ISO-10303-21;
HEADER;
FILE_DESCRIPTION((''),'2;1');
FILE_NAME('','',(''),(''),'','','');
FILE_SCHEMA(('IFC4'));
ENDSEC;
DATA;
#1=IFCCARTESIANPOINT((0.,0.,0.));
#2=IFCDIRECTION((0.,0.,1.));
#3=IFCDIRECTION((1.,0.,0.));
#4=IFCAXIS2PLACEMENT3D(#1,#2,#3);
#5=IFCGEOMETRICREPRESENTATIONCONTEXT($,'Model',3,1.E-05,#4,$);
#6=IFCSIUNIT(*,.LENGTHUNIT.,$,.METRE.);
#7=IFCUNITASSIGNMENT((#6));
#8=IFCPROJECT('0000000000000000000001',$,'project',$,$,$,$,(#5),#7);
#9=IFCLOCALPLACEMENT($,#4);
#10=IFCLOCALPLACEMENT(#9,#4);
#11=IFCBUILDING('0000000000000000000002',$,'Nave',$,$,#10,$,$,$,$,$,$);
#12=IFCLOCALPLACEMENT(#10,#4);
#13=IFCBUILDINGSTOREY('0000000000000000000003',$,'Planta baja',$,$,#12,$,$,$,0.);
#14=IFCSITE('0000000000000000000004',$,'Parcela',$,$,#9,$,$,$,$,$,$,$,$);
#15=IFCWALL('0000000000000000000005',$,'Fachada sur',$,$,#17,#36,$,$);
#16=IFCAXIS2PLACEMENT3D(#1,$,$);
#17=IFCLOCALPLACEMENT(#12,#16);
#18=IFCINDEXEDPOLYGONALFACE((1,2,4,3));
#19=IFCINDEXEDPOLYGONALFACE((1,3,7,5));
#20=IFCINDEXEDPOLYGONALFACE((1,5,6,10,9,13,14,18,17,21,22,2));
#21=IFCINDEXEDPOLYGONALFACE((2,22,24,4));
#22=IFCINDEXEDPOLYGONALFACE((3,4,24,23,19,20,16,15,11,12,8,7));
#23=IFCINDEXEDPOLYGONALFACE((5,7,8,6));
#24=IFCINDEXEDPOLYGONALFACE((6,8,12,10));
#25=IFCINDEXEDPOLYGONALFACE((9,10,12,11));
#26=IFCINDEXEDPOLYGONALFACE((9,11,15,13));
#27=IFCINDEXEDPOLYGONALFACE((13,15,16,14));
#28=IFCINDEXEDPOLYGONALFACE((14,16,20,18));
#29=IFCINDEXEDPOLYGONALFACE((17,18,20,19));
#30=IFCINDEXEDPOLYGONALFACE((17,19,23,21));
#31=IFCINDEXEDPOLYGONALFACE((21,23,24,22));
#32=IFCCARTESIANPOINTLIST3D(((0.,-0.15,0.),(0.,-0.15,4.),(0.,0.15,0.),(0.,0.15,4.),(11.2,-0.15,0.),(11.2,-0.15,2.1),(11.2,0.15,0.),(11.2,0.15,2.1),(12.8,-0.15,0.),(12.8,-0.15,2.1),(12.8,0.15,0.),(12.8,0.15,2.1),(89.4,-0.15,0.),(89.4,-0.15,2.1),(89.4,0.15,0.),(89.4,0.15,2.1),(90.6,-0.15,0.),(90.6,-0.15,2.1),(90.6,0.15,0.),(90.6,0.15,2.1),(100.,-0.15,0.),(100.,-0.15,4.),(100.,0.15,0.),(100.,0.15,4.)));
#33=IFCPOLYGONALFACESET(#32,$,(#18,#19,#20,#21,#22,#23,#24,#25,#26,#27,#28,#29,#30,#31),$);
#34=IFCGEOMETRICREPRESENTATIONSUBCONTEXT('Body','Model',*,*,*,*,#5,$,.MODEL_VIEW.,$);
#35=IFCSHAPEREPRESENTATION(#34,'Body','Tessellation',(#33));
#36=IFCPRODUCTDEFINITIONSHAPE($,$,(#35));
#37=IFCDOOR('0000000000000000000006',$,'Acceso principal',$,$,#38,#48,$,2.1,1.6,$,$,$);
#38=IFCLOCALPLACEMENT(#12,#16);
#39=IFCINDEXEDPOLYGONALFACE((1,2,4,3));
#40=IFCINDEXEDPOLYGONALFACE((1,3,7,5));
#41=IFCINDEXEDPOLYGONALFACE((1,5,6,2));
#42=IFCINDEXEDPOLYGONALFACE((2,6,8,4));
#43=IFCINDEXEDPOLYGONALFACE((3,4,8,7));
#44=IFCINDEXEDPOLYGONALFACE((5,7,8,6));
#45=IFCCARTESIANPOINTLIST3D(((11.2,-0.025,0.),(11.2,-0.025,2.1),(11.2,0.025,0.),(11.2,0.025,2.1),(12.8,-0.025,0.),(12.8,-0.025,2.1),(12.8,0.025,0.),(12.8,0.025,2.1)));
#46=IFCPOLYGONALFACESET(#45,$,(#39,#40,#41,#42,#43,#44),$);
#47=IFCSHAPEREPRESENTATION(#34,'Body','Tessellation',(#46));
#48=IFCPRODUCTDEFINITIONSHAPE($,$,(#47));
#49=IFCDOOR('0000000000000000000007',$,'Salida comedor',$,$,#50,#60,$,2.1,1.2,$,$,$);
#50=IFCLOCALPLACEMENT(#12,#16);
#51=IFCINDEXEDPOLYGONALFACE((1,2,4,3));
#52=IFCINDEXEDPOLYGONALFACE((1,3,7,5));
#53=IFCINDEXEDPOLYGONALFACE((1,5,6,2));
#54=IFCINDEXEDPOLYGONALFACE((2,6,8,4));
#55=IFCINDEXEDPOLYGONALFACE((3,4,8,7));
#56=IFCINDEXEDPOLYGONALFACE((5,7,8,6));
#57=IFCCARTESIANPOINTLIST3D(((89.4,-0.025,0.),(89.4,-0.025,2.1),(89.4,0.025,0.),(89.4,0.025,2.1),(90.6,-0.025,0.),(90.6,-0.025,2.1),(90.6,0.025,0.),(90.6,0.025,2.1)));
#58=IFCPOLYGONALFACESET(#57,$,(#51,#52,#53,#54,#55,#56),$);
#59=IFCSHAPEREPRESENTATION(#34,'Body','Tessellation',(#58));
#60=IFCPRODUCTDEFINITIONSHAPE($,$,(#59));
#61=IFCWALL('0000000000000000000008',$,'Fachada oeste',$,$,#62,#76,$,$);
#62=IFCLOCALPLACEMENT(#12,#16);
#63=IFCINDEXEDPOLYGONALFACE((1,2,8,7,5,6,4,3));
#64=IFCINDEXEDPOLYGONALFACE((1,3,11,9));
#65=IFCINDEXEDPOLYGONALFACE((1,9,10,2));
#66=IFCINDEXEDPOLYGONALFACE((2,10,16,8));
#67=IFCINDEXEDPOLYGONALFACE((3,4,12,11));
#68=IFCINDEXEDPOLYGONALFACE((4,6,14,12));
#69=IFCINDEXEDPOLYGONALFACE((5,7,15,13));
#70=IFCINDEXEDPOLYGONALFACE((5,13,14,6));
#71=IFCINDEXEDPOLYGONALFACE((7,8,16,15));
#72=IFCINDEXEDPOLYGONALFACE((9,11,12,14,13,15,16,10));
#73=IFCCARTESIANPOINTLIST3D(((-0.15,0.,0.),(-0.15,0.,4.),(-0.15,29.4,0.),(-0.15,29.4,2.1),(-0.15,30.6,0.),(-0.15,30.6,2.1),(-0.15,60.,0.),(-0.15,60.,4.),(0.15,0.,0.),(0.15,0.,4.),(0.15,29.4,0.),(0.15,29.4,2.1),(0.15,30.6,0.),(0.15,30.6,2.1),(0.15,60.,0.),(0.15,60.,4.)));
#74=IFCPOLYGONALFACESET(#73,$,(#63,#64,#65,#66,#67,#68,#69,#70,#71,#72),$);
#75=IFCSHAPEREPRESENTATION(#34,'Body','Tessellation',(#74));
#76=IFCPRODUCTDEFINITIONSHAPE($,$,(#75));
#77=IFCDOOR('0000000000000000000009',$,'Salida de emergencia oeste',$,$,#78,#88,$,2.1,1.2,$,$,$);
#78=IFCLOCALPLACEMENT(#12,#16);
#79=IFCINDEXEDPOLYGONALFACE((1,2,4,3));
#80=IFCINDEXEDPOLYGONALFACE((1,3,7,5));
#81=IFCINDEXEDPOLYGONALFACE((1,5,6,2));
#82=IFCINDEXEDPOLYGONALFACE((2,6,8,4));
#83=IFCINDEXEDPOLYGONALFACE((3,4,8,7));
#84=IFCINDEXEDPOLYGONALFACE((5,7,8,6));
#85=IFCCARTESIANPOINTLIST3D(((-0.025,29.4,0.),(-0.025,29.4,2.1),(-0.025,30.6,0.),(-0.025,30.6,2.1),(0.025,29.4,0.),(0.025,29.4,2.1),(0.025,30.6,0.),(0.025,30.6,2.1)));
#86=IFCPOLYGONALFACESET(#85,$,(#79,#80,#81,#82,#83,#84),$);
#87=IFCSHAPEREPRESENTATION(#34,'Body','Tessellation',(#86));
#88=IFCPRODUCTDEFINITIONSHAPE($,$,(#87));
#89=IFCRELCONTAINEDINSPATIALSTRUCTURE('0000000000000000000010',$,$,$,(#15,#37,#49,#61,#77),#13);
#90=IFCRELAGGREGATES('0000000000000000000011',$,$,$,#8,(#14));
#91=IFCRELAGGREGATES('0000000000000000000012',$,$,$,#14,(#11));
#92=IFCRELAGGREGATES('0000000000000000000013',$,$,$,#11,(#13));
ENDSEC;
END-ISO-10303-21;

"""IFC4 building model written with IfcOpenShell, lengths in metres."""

from ifc_helpers import new_model, si_unit, frame, origin_with_axes, place, context, subcontext, project, spatial, indexed_curve, outline, extrude, element, fill, save


model = new_model("IFC4")

# Units and contexts
model_context = context("Model", 3, precision=1e-05, world=origin_with_axes())
body_context = subcontext(model_context, "Body", "Model", "MODEL_VIEW")
ifc_project = project(units=[si_unit("LENGTHUNIT", "METRE")], contexts=[model_context])

# Site, building, storey
site_placement = place(None, origin_with_axes())
site = spatial("IfcSite", under=ifc_project, at=site_placement, Name="Parcela")
building_placement = place(site_placement, origin_with_axes())
building = spatial("IfcBuilding", under=site, at=building_placement, Name="Nave")
storey_placement = place(building_placement, origin_with_axes())
storey = spatial("IfcBuildingStorey", under=building, at=storey_placement, Name="Planta baja", Elevation=0.0)

# Wall, openings, doors
wall_1_placement = place(storey_placement, frame((0.0, -0.15, 0.0), z_axis=(0.0, 0.0, 1.0), x_axis=(1.0, 0.0, 0.0)))
wall_1 = element("IfcWall", 1, at=wall_1_placement, inside=storey, Name="Fachada sur", context=body_context, shape_type="SweptSolid", body=[
    extrude(outline(indexed_curve([(0.0, 0.0), (0.0, 0.3), (100.0, 0.3), (100.0, 0.0), (0.0, 0.0)], self_intersect=False)), origin_with_axes(), (0.0, 0.0, 1.0), 4.0),
])
opening_1_placement = place(wall_1_placement, frame((11.2, -0.05, 0.0), z_axis=(0.0, 0.0, 1.0), x_axis=(1.0, 0.0, 0.0)))
opening_1 = element("IfcOpeningElement", 2, at=opening_1_placement, cuts=wall_1, context=body_context, shape_type="SweptSolid", body=[
    extrude(outline(indexed_curve([(0.0, 0.0), (0.0, 0.4), (1.6, 0.4), (1.6, 0.0), (0.0, 0.0)], self_intersect=False)), origin_with_axes(), (0.0, 0.0, 1.0), 2.1),
])
opening_2_placement = place(wall_1_placement, frame((89.4, -0.05, 0.0), z_axis=(0.0, 0.0, 1.0), x_axis=(1.0, 0.0, 0.0)))
opening_2 = element("IfcOpeningElement", 3, at=opening_2_placement, cuts=wall_1, context=body_context, shape_type="SweptSolid", body=[
    extrude(outline(indexed_curve([(0.0, 0.0), (0.0, 0.4), (1.2, 0.4), (1.2, 0.0), (0.0, 0.0)], self_intersect=False)), origin_with_axes(), (0.0, 0.0, 1.0), 2.1),
])
door_1_placement = place(opening_1_placement, frame((0.0, 0.175, 0.0), z_axis=(0.0, 0.0, 1.0), x_axis=(1.0, 0.0, 0.0)))
door_1 = element("IfcDoor", 4, at=door_1_placement, inside=storey, Name="Acceso principal", OverallHeight=2.1, OverallWidth=1.6, context=body_context, shape_type="SweptSolid", body=[
    extrude(outline(indexed_curve([(0.0, 0.0), (0.0, 0.05), (1.6, 0.05), (1.6, 0.0), (0.0, 0.0)], self_intersect=False)), origin_with_axes(), (0.0, 0.0, 1.0), 2.1),
])
fill(opening_1, door_1)
door_2_placement = place(opening_2_placement, frame((0.0, 0.175, 0.0), z_axis=(0.0, 0.0, 1.0), x_axis=(1.0, 0.0, 0.0)))
door_2 = element("IfcDoor", 5, at=door_2_placement, inside=storey, Name="Salida comedor", OverallHeight=2.1, OverallWidth=1.2, context=body_context, shape_type="SweptSolid", body=[
    extrude(outline(indexed_curve([(0.0, 0.0), (0.0, 0.05), (1.2, 0.05), (1.2, 0.0), (0.0, 0.0)], self_intersect=False)), origin_with_axes(), (0.0, 0.0, 1.0), 2.1),
])
fill(opening_2, door_2)

# Wall, opening, door
wall_2_placement = place(storey_placement, frame((0.15, 0.0, 0.0), z_axis=(0.0, 0.0, 1.0), x_axis=(0.0, 1.0, 0.0)))
wall_2 = element("IfcWall", 6, at=wall_2_placement, inside=storey, Name="Fachada oeste", context=body_context, shape_type="SweptSolid", body=[
    extrude(outline(indexed_curve([(0.0, 0.0), (0.0, 0.3), (60.0, 0.3), (60.0, 0.0), (0.0, 0.0)], self_intersect=False)), origin_with_axes(), (0.0, 0.0, 1.0), 4.0),
])
opening_3_placement = place(wall_2_placement, frame((29.4, -0.05, 0.0), z_axis=(0.0, 0.0, 1.0), x_axis=(1.0, 0.0, 0.0)))
opening_3 = element("IfcOpeningElement", 7, at=opening_3_placement, cuts=wall_2, context=body_context, shape_type="SweptSolid", body=[
    extrude(outline(indexed_curve([(0.0, 0.0), (0.0, 0.4), (1.2, 0.4), (1.2, 0.0), (0.0, 0.0)], self_intersect=False)), origin_with_axes(), (0.0, 0.0, 1.0), 2.1),
])
door_3_placement = place(opening_3_placement, frame((0.0, 0.175, 0.0), z_axis=(0.0, 0.0, 1.0), x_axis=(1.0, 0.0, 0.0)))
door_3 = element("IfcDoor", 8, at=door_3_placement, inside=storey, Name="Salida de emergencia oeste", OverallHeight=2.1, OverallWidth=1.2, context=body_context, shape_type="SweptSolid", body=[
    extrude(outline(indexed_curve([(0.0, 0.0), (0.0, 0.05), (1.2, 0.05), (1.2, 0.0), (0.0, 0.0)], self_intersect=False)), origin_with_axes(), (0.0, 0.0, 1.0), 2.1),
])
fill(opening_3, door_3)

save(model, "model.ifc")
